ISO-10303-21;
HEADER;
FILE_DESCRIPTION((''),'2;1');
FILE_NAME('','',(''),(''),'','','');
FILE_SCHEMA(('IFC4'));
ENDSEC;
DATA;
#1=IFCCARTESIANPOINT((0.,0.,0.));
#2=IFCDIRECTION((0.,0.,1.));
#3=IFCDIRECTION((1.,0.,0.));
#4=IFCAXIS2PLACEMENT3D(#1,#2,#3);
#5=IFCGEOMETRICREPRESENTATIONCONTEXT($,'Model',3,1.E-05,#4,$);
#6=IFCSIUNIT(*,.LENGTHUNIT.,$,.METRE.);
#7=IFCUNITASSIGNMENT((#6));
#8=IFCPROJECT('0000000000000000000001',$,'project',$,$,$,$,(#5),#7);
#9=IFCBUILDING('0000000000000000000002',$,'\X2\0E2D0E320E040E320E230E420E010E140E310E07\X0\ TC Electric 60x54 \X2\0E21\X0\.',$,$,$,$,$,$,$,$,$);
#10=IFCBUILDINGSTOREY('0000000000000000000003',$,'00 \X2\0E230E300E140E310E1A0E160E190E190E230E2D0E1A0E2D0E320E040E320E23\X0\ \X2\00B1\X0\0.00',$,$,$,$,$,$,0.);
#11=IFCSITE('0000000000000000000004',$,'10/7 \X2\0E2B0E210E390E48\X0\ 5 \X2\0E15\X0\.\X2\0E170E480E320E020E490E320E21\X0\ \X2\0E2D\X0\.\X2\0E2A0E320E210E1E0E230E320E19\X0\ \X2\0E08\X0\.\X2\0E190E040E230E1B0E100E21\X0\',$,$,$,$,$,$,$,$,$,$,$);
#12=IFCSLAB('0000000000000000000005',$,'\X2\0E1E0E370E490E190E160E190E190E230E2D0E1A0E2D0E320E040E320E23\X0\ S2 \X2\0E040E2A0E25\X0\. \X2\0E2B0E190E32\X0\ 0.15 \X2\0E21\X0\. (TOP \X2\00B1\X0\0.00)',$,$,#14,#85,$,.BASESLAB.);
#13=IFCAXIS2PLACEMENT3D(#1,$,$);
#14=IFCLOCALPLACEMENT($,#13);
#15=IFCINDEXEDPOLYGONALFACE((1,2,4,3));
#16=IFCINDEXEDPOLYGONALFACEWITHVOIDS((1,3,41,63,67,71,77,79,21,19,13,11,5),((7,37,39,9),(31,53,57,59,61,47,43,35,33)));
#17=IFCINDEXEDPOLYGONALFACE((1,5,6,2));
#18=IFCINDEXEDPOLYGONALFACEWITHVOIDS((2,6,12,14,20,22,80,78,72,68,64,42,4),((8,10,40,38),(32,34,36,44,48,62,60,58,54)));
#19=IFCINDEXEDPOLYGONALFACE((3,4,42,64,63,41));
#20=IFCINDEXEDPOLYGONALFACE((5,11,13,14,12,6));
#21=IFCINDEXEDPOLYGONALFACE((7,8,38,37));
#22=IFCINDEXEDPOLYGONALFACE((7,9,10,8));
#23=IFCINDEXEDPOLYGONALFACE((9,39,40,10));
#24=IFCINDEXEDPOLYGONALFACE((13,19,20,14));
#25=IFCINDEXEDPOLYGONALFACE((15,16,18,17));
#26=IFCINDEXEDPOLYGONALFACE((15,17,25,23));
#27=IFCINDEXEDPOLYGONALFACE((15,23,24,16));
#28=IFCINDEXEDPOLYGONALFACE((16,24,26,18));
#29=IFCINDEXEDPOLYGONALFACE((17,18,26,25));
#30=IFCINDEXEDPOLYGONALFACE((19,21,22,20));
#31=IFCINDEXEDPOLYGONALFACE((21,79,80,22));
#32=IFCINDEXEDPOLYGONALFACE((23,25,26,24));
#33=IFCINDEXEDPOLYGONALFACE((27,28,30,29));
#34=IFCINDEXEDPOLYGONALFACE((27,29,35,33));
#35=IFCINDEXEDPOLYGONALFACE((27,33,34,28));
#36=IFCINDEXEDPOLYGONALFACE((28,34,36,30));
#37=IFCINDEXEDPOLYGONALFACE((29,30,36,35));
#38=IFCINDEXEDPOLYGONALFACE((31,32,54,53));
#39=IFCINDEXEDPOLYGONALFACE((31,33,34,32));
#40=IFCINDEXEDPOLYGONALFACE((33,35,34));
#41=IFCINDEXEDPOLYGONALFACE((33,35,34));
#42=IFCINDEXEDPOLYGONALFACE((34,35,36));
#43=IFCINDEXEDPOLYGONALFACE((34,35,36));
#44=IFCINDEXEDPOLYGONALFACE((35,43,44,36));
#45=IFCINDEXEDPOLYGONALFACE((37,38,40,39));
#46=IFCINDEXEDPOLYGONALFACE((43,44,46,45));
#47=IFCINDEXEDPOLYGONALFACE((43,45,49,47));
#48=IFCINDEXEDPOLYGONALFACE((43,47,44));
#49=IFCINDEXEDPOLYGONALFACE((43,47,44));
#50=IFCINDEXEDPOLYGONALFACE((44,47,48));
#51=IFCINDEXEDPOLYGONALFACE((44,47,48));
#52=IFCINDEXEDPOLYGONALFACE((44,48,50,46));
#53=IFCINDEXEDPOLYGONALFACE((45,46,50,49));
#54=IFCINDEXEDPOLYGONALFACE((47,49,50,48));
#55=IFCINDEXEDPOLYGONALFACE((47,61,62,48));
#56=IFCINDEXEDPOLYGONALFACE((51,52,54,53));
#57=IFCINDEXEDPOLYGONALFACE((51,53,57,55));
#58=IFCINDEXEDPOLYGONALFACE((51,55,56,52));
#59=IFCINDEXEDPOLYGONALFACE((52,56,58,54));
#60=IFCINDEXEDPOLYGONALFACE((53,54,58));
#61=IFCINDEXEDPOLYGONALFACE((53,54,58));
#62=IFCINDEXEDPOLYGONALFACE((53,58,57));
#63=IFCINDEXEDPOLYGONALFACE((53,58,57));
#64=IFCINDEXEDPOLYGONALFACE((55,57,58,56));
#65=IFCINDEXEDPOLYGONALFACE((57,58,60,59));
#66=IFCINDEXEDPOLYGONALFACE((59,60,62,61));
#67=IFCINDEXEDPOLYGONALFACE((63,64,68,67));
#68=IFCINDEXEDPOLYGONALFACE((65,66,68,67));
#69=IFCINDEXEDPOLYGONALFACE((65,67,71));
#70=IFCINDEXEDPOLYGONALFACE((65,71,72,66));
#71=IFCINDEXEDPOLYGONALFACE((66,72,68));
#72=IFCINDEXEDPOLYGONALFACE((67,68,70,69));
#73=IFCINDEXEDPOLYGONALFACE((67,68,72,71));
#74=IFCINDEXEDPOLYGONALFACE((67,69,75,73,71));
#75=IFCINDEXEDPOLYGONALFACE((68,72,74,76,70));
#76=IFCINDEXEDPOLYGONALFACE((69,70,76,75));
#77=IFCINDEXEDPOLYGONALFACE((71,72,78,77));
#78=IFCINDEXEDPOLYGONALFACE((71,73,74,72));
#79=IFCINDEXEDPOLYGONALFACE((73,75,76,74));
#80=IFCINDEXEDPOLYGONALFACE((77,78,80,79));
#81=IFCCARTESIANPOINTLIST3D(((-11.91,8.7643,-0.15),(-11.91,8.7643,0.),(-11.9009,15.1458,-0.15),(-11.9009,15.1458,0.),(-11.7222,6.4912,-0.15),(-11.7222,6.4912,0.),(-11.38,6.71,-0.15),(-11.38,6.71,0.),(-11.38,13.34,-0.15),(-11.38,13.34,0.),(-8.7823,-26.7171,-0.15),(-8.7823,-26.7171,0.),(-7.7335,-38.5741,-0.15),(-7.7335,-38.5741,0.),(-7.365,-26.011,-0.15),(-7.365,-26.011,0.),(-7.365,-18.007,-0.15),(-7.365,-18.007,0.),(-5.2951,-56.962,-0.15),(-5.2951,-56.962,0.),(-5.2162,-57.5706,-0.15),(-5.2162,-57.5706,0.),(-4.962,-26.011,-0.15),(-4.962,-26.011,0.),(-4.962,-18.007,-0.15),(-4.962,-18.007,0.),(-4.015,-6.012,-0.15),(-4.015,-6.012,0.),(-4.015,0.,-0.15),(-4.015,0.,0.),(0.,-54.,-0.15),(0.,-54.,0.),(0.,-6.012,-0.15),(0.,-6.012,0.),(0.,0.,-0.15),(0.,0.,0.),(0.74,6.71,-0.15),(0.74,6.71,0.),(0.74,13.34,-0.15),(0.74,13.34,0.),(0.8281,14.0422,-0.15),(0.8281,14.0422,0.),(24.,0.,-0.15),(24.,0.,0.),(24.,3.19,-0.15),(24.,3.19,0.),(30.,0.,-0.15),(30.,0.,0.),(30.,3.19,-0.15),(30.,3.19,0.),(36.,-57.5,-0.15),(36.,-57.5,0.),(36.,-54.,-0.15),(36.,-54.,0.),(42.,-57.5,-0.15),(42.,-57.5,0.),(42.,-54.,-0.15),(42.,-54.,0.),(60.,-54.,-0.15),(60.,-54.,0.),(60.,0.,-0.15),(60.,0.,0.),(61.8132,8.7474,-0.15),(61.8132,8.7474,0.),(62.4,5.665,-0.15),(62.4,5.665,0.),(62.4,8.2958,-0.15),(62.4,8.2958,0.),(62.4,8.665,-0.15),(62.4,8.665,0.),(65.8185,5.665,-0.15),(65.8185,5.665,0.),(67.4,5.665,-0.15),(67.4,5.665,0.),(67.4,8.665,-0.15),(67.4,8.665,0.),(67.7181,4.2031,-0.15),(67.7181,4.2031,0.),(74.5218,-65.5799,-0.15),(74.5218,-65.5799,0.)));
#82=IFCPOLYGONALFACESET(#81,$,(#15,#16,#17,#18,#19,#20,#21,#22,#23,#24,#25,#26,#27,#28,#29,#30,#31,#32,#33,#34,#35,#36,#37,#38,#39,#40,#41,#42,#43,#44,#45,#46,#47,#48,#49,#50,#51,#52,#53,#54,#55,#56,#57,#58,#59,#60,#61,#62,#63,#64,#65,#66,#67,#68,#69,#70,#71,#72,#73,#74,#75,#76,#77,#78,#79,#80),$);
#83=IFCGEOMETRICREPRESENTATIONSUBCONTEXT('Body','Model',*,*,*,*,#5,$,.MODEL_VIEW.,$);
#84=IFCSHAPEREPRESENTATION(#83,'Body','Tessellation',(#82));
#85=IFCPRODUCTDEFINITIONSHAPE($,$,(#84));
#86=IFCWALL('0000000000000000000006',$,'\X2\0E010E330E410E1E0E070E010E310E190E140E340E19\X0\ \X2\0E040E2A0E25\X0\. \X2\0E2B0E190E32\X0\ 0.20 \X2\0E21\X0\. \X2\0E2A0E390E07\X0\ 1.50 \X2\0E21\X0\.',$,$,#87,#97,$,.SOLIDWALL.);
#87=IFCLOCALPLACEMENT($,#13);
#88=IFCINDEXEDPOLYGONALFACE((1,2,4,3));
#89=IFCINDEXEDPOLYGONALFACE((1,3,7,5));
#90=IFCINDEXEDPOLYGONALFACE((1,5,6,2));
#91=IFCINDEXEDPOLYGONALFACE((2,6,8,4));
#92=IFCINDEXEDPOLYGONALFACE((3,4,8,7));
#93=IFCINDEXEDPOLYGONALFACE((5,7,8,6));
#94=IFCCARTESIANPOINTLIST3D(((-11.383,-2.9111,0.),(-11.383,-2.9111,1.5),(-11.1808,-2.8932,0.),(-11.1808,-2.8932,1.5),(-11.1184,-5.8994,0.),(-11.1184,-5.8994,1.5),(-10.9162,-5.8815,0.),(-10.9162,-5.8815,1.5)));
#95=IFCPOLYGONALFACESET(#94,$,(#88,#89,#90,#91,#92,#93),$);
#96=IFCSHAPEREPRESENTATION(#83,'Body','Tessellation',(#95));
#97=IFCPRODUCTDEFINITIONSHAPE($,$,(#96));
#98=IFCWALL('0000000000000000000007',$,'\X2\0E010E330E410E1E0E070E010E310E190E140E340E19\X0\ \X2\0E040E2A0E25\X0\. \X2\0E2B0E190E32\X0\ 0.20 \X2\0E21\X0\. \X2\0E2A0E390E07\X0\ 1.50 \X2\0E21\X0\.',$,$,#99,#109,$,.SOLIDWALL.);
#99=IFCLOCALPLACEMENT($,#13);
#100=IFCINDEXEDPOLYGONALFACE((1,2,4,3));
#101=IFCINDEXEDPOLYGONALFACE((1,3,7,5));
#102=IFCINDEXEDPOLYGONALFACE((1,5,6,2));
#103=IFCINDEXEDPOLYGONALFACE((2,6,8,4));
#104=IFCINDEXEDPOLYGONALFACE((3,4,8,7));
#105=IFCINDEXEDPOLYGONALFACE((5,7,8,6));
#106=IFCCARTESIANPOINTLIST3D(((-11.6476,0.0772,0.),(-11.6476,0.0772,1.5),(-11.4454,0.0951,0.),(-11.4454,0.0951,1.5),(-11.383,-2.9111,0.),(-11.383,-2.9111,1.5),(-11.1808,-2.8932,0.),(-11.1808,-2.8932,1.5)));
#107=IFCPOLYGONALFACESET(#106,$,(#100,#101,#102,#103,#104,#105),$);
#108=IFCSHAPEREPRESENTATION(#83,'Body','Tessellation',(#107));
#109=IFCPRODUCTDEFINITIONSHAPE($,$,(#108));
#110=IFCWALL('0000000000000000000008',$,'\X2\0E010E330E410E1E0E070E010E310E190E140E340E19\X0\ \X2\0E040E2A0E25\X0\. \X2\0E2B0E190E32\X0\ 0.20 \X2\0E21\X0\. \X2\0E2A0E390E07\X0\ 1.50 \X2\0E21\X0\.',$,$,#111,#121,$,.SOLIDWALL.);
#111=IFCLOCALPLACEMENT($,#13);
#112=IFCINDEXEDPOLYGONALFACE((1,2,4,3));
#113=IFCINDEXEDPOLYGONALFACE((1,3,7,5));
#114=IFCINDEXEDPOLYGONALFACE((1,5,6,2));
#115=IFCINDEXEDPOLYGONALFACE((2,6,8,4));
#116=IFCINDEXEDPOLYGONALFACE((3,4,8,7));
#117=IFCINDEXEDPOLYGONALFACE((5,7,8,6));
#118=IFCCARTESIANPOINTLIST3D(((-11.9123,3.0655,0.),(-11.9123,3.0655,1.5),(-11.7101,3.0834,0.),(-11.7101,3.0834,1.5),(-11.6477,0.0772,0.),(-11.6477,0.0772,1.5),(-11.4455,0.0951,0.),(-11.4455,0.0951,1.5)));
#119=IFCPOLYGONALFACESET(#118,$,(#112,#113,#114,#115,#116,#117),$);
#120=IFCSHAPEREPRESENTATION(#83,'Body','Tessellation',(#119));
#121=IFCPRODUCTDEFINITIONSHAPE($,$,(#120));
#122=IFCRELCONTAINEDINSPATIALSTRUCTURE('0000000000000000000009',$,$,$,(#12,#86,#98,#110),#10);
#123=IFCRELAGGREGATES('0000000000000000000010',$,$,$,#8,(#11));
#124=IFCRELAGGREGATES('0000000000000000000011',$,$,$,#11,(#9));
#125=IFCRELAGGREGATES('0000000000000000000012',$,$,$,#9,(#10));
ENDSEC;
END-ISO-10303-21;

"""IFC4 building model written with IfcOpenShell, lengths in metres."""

from ifc_helpers import new_model, si_unit, frame, origin, origin_with_axes, origin_2d, place, context, subcontext, project, spatial, polyline, rectangle, outline, extrude, element, save


model = new_model("IFC4")

# Units and contexts
model_context = context("Model", 3, precision=1e-05, world=origin_with_axes())
body_context = subcontext(model_context, "Body", "Model", "MODEL_VIEW")
ifc_project = project(units=[si_unit("LENGTHUNIT", "METRE")], contexts=[model_context])

# Site, building, storey
site = spatial("IfcSite", under=ifc_project, Name="10/7 หมู่ 5 ต.ท่าข้าม อ.สามพราน จ.นครปฐม")
building = spatial("IfcBuilding", under=site, Name="อาคารโกดัง TC Electric 60x54 ม.")
storey = spatial("IfcBuildingStorey", under=building, Name="00 ระดับถนนรอบอาคาร ±0.00", Elevation=0.0)

# Slab
slab_placement = place(None, frame((0.0, 0.0, -0.15), z_axis=(0.0, 0.0, 1.0), x_axis=(1.0, 0.0, 0.0)))
element("IfcSlab", 1, at=slab_placement, inside=storey, Name="พื้นถนนรอบอาคาร S2 คสล. หนา 0.15 ม. (TOP ±0.00)", PredefinedType="BASESLAB", context=body_context, shape_type="SweptSolid", body=[
    extrude(outline(polyline([(-11.9009, 15.1458), (0.8281, 14.0422), (61.8132, 8.7474), (67.7181, 4.2031), (74.5218, -65.5799), (-5.2162, -57.5706), (-5.2951, -56.962), (-7.7335, -38.5741), (-8.7823, -26.7171), (-11.7222, 6.4912), (-11.91, 8.7643), (-11.9009, 15.1458)]), holes=[polyline([(0.0, 0.0), (60.0, 0.0), (60.0, -54.0), (0.0, -54.0), (0.0, 0.0)]), polyline([(-11.38, 13.34), (0.74, 13.34), (0.74, 6.71), (-11.38, 6.71), (-11.38, 13.34)]), polyline([(62.4, 8.665), (67.4, 8.665), (67.4, 5.665), (62.4, 5.665), (62.4, 8.665)]), polyline([(-7.365, -18.007), (-4.962, -18.007), (-4.962, -26.011), (-7.365, -26.011), (-7.365, -18.007)]), polyline([(-4.015, 0.0), (0.0, 0.0), (0.0, -6.012), (-4.015, -6.012), (-4.015, 0.0)]), polyline([(24.0, 3.19), (30.0, 3.19), (30.0, 0.0), (24.0, 0.0), (24.0, 3.19)]), polyline([(36.0, -54.0), (42.0, -54.0), (42.0, -57.5), (36.0, -57.5), (36.0, -54.0)])]), origin(), (0.0, 0.0, 1.0), 0.15),
])

# Walls
for number, where, z_axis, x_axis, name in (
    (2, (-11.1496, -4.3963, 0.0), (0.0, 0.0, 1.0), (-0.0882, 0.9961, 0.0), "กำแพงกันดิน คสล. หนา 0.20 ม. สูง 1.50 ม."),
    (3, (-11.4142, -1.408, 0.0), (0.0, 0.0, 1.0), (-0.0882, 0.9961, 0.0), "กำแพงกันดิน คสล. หนา 0.20 ม. สูง 1.50 ม."),
    (4, (-11.6789, 1.5803, 0.0), (0.0, 0.0, 1.0), (-0.0882, 0.9961, 0.0), "กำแพงกันดิน คสล. หนา 0.20 ม. สูง 1.50 ม."),
):
    element("IfcWall", number, at=place(None, frame(where, z_axis=z_axis, x_axis=x_axis)), inside=storey, Name=name, PredefinedType="SOLIDWALL", context=body_context, shape_type="SweptSolid", body=[
        extrude(rectangle(XDim=3.0, YDim=0.203, at=origin_2d()), origin(), (0.0, 0.0, 1.0), 1.5),
    ])

save(model, "model.ifc")
